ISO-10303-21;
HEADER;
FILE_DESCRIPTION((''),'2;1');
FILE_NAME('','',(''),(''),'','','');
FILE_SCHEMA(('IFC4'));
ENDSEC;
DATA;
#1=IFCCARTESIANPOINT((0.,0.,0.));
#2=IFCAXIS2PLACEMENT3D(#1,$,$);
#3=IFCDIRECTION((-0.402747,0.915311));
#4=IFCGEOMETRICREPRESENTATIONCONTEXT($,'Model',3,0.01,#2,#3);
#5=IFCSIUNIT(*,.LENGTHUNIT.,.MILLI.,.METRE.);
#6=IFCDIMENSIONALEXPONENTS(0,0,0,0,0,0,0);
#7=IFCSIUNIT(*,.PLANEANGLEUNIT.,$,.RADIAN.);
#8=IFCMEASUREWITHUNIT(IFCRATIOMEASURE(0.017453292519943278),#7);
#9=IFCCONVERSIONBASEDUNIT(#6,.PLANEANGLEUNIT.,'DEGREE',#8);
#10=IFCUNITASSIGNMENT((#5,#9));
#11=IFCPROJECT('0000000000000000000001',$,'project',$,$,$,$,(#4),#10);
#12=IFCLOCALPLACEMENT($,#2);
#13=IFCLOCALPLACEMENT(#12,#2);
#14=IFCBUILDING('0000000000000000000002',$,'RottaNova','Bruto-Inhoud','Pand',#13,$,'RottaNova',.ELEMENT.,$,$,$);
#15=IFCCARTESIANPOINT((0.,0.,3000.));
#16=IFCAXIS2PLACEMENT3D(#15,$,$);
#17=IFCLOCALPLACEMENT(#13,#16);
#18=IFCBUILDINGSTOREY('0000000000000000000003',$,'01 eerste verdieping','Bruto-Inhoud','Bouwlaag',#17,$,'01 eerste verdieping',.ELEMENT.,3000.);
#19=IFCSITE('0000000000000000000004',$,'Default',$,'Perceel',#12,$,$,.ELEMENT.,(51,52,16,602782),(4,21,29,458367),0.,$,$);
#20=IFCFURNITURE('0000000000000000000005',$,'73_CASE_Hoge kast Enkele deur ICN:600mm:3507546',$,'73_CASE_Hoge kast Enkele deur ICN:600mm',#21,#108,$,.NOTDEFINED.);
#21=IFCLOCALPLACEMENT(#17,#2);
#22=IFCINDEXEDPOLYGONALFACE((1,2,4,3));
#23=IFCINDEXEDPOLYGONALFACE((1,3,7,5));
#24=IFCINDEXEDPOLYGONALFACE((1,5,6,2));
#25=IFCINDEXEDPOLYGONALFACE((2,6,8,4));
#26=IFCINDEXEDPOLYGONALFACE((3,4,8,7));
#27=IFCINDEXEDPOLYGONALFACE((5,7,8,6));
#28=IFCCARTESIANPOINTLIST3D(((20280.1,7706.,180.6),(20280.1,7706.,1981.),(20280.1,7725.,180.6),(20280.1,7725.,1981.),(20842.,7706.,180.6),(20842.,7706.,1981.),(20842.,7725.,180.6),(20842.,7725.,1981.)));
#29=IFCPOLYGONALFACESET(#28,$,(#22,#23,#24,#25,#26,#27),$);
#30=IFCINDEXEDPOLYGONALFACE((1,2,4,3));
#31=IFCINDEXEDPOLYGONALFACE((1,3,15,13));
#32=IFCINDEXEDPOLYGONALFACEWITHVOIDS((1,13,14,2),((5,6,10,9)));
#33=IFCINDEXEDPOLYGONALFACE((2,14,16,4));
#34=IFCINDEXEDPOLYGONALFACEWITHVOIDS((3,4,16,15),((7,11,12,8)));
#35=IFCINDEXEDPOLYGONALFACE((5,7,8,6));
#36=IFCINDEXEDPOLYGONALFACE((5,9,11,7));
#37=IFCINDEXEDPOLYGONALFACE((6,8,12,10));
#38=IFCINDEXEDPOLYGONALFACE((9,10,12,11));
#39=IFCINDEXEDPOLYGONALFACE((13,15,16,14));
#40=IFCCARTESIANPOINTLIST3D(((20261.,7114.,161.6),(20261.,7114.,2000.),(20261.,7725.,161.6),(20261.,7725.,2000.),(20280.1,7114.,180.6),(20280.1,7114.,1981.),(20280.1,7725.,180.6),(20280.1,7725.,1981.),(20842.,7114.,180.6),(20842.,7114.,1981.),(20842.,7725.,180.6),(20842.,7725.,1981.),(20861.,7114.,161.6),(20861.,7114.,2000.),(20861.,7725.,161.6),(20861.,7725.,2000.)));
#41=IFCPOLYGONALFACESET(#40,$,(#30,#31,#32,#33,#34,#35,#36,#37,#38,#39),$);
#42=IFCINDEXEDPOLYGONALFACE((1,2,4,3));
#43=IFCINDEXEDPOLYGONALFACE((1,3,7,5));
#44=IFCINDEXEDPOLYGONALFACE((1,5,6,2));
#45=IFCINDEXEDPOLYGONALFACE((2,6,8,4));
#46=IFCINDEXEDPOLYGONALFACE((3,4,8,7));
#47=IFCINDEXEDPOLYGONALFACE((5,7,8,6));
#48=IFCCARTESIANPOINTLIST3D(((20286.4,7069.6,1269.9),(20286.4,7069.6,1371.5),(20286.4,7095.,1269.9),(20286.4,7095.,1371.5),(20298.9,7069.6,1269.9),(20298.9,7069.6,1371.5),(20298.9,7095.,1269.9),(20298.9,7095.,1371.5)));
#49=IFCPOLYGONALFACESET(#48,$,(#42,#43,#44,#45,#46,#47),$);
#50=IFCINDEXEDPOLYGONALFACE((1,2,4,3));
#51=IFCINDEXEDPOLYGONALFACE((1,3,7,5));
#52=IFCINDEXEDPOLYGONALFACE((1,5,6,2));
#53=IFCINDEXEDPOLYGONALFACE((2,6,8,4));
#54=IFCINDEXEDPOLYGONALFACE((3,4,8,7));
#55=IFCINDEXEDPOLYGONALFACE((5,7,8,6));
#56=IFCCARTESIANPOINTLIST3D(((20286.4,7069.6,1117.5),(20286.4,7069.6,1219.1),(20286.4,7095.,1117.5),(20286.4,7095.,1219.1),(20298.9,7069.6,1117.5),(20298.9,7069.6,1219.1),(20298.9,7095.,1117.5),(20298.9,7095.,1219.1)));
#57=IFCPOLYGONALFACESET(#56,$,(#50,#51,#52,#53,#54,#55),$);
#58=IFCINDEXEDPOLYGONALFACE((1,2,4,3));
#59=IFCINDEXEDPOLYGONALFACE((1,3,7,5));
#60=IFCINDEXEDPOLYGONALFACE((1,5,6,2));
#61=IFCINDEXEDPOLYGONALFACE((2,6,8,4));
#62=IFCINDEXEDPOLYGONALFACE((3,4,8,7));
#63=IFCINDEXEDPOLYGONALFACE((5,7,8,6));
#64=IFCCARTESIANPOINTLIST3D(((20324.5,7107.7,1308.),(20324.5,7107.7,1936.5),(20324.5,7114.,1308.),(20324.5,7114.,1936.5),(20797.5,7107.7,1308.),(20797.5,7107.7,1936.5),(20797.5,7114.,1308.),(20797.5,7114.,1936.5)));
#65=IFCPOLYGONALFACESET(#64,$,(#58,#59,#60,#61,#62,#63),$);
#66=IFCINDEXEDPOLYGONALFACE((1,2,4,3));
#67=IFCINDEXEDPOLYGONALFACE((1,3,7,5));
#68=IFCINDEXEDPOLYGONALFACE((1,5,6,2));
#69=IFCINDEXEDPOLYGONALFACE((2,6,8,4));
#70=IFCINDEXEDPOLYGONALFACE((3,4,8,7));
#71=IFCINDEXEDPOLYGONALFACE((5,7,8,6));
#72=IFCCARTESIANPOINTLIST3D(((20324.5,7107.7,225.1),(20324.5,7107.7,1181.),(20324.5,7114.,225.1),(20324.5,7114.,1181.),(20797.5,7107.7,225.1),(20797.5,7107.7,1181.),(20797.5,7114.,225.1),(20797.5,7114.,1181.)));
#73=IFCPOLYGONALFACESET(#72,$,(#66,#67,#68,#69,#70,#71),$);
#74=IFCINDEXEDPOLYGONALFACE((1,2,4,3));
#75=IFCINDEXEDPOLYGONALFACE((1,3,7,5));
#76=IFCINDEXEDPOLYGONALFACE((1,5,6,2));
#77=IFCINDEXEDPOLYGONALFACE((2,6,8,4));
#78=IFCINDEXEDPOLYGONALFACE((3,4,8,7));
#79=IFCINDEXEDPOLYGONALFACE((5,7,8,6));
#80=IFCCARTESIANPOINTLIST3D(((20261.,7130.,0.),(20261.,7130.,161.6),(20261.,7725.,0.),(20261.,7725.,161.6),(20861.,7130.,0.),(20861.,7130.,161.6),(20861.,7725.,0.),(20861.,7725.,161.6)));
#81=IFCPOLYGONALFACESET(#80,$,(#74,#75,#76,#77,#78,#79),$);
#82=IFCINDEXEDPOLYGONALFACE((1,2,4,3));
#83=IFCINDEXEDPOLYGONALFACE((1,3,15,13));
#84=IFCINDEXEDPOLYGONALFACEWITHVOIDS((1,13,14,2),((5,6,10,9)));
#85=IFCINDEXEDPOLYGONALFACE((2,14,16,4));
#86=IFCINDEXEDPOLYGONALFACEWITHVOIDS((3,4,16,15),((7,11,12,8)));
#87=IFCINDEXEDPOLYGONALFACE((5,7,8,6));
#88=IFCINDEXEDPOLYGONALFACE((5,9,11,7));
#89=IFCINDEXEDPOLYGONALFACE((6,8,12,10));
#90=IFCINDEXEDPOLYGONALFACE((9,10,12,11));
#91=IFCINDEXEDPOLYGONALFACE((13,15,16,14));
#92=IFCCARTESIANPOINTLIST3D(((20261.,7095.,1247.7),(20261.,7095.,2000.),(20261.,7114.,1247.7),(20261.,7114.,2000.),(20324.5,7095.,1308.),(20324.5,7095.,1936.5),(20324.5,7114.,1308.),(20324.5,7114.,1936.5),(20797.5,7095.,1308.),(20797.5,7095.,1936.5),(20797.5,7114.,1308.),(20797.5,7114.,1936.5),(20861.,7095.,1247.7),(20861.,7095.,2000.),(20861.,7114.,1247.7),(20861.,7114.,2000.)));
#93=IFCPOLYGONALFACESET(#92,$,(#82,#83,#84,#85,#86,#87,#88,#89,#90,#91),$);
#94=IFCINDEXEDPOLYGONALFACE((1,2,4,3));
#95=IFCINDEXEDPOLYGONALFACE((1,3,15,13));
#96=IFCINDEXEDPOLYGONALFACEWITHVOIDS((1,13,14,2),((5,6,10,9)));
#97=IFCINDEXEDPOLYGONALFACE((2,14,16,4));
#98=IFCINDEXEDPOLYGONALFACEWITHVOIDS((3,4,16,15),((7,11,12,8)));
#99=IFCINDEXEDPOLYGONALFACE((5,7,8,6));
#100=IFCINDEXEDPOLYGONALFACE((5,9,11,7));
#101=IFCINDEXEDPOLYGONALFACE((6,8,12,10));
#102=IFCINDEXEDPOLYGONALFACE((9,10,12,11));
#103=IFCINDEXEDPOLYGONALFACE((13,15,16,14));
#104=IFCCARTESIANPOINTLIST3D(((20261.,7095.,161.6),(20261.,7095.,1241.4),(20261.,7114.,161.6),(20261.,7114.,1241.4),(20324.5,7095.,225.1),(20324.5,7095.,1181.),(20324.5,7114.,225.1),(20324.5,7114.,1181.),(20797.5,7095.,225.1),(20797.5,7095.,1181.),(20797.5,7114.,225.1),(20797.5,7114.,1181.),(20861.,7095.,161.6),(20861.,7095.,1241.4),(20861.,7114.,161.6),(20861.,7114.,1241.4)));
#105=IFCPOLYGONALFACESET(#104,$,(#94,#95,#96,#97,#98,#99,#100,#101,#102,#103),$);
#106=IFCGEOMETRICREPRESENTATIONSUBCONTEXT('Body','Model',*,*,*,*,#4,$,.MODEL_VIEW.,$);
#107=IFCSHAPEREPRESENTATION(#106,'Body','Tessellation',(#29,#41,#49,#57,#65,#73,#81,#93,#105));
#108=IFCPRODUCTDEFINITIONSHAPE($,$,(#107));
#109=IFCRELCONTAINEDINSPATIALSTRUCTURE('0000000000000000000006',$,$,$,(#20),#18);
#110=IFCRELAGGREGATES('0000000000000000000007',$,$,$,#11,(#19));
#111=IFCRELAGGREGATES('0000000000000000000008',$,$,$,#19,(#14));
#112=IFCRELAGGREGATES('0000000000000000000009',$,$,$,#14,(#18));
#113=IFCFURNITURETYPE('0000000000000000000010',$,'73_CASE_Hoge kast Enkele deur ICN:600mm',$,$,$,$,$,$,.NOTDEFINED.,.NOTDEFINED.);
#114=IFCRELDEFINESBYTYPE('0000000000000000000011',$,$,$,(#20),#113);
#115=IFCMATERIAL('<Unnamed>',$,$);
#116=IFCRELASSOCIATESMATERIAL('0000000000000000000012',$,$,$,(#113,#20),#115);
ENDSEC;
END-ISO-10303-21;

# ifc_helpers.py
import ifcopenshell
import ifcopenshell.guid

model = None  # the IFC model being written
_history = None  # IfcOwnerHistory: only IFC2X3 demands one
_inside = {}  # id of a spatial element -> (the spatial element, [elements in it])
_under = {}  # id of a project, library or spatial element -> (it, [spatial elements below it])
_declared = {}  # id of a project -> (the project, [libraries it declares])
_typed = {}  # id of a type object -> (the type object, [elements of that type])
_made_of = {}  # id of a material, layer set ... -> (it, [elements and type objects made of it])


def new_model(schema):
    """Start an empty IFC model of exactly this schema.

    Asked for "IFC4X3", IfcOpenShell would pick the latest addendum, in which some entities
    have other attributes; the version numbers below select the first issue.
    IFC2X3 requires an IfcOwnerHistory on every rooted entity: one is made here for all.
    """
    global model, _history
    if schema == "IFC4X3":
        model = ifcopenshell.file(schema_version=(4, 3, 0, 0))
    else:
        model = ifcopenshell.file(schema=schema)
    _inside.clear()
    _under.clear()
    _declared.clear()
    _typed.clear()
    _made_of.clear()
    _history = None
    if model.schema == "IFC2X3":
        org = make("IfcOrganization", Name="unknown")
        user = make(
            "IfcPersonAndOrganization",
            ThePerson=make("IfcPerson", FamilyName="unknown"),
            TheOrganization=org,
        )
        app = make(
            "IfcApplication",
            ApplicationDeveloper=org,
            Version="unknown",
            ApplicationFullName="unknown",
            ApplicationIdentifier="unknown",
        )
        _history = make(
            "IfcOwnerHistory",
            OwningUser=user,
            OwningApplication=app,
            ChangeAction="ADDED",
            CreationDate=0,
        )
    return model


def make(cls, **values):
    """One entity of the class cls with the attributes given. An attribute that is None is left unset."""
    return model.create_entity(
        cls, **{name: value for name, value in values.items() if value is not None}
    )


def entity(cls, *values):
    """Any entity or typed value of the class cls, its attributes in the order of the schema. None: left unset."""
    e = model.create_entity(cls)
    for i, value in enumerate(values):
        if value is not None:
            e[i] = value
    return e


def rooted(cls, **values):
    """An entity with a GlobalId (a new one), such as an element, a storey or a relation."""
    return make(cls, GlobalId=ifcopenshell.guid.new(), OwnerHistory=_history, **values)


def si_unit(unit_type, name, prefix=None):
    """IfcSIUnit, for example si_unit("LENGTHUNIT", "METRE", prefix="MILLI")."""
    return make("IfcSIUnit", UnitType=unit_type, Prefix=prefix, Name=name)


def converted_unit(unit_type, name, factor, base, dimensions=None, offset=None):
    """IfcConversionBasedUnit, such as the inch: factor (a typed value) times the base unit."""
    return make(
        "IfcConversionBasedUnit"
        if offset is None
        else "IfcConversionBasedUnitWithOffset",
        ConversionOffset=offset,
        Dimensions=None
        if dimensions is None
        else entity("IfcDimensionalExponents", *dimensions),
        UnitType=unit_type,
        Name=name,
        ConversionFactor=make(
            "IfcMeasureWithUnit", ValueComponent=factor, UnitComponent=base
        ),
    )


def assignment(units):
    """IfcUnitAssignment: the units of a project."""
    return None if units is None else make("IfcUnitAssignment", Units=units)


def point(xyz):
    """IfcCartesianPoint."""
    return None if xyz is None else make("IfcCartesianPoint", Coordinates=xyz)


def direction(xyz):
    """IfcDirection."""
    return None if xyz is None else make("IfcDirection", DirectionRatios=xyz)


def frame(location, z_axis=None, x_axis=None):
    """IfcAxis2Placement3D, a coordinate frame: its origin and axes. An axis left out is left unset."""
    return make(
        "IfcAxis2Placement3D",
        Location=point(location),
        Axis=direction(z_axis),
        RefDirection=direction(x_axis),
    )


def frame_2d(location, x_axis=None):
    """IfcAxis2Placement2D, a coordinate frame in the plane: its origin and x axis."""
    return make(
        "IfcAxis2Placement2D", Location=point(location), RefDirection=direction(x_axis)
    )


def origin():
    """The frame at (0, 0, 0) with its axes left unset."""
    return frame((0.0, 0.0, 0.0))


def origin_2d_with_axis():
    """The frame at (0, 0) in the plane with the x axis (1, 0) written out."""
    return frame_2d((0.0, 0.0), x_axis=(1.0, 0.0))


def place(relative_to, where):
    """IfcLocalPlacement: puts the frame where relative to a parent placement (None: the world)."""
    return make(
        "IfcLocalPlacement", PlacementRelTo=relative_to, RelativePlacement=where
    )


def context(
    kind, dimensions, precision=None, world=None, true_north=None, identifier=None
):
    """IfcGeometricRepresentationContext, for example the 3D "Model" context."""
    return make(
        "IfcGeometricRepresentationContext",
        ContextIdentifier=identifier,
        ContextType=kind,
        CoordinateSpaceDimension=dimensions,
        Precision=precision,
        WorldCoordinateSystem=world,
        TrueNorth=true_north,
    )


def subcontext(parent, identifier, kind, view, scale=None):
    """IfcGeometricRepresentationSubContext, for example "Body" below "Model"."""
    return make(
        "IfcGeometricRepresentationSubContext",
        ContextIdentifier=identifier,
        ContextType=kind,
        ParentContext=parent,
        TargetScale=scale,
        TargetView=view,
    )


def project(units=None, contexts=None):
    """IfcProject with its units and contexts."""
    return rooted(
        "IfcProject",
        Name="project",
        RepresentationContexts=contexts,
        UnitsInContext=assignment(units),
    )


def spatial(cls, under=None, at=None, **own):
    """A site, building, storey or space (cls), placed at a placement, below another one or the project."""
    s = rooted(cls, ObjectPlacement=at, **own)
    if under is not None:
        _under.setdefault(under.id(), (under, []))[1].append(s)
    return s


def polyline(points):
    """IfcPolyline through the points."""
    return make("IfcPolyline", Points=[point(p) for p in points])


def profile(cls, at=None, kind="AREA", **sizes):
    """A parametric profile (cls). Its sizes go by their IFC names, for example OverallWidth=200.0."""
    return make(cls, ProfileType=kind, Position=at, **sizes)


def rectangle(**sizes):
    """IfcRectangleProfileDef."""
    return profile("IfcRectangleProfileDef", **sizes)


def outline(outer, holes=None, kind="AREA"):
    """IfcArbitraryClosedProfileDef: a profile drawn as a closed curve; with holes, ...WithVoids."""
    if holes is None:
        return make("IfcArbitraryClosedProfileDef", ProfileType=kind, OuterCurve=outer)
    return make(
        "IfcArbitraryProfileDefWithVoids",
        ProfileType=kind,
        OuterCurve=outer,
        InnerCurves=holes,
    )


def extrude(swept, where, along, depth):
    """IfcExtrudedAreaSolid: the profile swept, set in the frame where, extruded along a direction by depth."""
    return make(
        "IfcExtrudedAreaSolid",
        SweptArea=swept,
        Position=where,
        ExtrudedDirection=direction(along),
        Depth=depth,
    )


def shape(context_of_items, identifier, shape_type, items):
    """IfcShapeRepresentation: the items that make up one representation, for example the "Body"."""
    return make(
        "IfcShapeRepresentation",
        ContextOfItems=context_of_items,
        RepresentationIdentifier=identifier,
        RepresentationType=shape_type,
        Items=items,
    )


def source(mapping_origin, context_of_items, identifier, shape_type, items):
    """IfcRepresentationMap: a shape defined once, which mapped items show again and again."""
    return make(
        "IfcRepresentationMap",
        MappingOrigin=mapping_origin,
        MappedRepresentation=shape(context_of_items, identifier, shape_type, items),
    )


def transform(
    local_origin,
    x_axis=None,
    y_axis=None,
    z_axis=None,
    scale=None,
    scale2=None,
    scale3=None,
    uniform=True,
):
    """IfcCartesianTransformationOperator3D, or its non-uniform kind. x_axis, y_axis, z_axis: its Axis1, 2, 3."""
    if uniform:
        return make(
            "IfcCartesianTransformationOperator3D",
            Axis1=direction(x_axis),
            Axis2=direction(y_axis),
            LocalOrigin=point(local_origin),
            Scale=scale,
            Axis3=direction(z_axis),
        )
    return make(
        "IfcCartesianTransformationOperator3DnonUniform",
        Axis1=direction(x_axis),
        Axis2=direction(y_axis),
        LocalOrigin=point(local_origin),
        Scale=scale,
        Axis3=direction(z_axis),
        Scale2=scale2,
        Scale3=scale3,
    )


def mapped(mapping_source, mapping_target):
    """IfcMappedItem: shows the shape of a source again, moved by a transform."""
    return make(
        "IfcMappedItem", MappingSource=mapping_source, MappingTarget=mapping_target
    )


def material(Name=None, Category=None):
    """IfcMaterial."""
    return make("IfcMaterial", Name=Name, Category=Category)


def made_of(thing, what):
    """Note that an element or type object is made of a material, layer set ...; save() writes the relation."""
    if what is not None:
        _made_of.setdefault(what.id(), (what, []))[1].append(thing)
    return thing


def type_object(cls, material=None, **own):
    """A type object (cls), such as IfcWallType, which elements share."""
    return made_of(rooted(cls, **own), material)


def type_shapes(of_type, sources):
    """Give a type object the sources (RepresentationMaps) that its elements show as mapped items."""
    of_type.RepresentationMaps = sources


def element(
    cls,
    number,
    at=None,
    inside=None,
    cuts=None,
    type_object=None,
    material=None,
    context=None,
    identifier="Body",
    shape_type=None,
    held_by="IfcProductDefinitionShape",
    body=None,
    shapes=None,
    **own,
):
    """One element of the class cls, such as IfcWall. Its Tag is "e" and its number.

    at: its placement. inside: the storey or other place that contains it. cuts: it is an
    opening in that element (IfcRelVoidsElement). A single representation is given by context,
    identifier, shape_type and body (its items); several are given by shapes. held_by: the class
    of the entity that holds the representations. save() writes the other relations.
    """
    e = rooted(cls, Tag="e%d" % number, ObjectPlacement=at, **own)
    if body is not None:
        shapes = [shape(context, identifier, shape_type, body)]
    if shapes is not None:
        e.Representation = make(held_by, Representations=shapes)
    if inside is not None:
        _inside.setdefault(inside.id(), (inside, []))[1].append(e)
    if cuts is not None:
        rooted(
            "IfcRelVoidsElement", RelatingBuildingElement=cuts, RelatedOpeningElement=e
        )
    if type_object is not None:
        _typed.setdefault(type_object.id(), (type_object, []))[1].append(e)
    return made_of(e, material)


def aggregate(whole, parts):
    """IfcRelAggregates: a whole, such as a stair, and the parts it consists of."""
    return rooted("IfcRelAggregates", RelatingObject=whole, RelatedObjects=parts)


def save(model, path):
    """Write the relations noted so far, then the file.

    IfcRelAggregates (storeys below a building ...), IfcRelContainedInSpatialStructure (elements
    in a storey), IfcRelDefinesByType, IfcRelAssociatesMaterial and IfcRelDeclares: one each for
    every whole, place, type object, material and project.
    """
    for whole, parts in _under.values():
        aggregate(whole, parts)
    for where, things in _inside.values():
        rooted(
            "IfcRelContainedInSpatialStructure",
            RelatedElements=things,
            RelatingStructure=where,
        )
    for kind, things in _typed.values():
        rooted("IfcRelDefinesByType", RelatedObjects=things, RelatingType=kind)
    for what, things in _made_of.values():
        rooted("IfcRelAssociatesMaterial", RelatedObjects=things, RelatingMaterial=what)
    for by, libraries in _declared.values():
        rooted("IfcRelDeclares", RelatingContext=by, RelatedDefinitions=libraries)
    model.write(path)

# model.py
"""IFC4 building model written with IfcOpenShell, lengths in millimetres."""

from ifc_helpers import new_model, entity, si_unit, converted_unit, direction, frame, frame_2d, origin, origin_2d_with_axis, place, context, subcontext, project, spatial, polyline, rectangle, outline, extrude, source, transform, mapped, material, type_object, type_shapes, element, save


model = new_model("IFC4")

# Units and contexts
model_context = context("Model", 3, precision=0.01, world=origin(), true_north=direction((-0.402747, 0.915311)))
body_context = subcontext(model_context, "Body", "Model", "MODEL_VIEW")
ifc_project = project(units=[si_unit("LENGTHUNIT", "METRE", prefix="MILLI"), converted_unit("PLANEANGLEUNIT", "DEGREE", entity("IfcRatioMeasure", 0.017453292519943278), si_unit("PLANEANGLEUNIT", "RADIAN"), dimensions=[0, 0, 0, 0, 0, 0, 0])], contexts=[model_context])

# Site, building, storey
site_placement = place(None, origin())
site = spatial("IfcSite", under=ifc_project, at=site_placement, Name="Default", ObjectType="Perceel", CompositionType="ELEMENT", RefLatitude=(51, 52, 16, 602782), RefLongitude=(4, 21, 29, 458367), RefElevation=0.0)
building_placement = place(site_placement, origin())
building = spatial("IfcBuilding", under=site, at=building_placement, Name="RottaNova", Description="Bruto-Inhoud", ObjectType="Pand", LongName="RottaNova", CompositionType="ELEMENT")
storey_placement = place(building_placement, frame((0.0, 0.0, 3000.0)))
storey = spatial("IfcBuildingStorey", under=building, at=storey_placement, Name="01 eerste verdieping", Description="Bruto-Inhoud", ObjectType="Bouwlaag", LongName="01 eerste verdieping", CompositionType="ELEMENT", Elevation=3000.0)

# Furniture
ifc_material_1 = material(Name="<Unnamed>")
furniture_type = type_object("IfcFurnitureType", Name="73_CASE_Hoge kast Enkele deur ICN:600mm", AssemblyPlace="NOTDEFINED", PredefinedType="NOTDEFINED", material=ifc_material_1)
shared_shape_1 = source(origin(), body_context, "Body", "SweptSolid", [
    extrude(rectangle(XDim=561.9, YDim=19.1, at=origin_2d_with_axis()), frame((18.7, 9.5, 180.6), z_axis=(0.0, 0.0, 1.0), x_axis=(-1.0, 0.0, 0.0)), (0.0, 0.0, 1.0), 1800.3),
    extrude(outline(polyline([(-300.0, -919.2), (300.0, -919.2), (300.0, 919.2), (-300.0, 919.2), (-300.0, -919.2)]), holes=[polyline([(-280.9, 900.2), (281.0, 900.2), (281.0, -900.2), (-280.9, -900.2), (-280.9, 900.2)])]), frame((18.7, 0.0, 1080.8), z_axis=(0.0, 1.0, 0.0), x_axis=(-1.0, 0.0, 0.0)), (0.0, 0.0, 1.0), 610.9),
    extrude(rectangle(XDim=12.5, YDim=25.4, at=frame_2d((0.0, 0.0), x_axis=(1.0, 0.0))), frame((287.1, 642.7, 1269.9), z_axis=(0.0, 0.0, 1.0), x_axis=(-1.0, 0.0, 0.0)), (0.0, 0.0, 1.0), 101.6),
    extrude(rectangle(XDim=12.5, YDim=25.4, at=frame_2d((0.0, 0.0), x_axis=(1.0, 0.0))), frame((287.1, 642.7, 1117.5), z_axis=(0.0, 0.0, 1.0), x_axis=(-1.0, 0.0, 0.0)), (0.0, 0.0, 1.0), 101.6),
    extrude(rectangle(XDim=473.0, YDim=6.4, at=origin_2d_with_axis()), frame((18.7, 614.1, 1308.0), z_axis=(0.0, 0.0, 1.0), x_axis=(-1.0, 0.0, 0.0)), (0.0, 0.0, 1.0), 628.5),
    extrude(rectangle(XDim=473.0, YDim=6.4, at=origin_2d_with_axis()), frame((18.7, 614.1, 225.1), z_axis=(0.0, 0.0, 1.0), x_axis=(-1.0, 0.0, 0.0)), (0.0, 0.0, 1.0), 956.0),
    extrude(rectangle(XDim=595.0, YDim=600.0, at=frame_2d((0.0, 0.0), x_axis=(1.0, 0.0))), frame((18.7, 297.5, 0.0), z_axis=(0.0, 0.0, 1.0), x_axis=(0.0, 1.0, 0.0)), (0.0, 0.0, 1.0), 161.6),
    extrude(outline(polyline([(-376.1, -300.0), (376.1, -300.0), (376.1, 300.0), (-376.1, 300.0), (-376.1, -300.0)]), holes=[polyline([(-312.6, -236.5), (-312.6, 236.5), (315.8, 236.5), (315.8, -236.5), (-312.6, -236.5)])]), frame((18.7, 610.9, 1623.9), z_axis=(0.0, 1.0, 0.0), x_axis=(0.0, 0.0, -1.0)), (0.0, 0.0, 1.0), 19.1),
    extrude(outline(polyline([(-300.0, -539.9), (300.0, -539.9), (300.0, 539.9), (-300.0, 539.9), (-300.0, -539.9)]), holes=[polyline([(-236.5, 479.6), (236.5, 479.6), (236.5, -476.4), (-236.5, -476.4), (-236.5, 479.6)])]), frame((18.7, 610.9, 701.5), z_axis=(0.0, 1.0, 0.0), x_axis=(-1.0, 0.0, 0.0)), (0.0, 0.0, 1.0), 19.1),
])
type_shapes(furniture_type, [shared_shape_1])
for number, where, z_axis, x_axis, name in (
    (1, (20579.7, 7725.0, 0.0), (0.0, 0.0, 1.0), (-1.0, 0.0, 0.0), "73_CASE_Hoge kast Enkele deur ICN:600mm:3507546"),
):
    element("IfcFurniture", number, at=place(storey_placement, frame(where, z_axis=z_axis, x_axis=x_axis)), inside=storey, type_object=furniture_type, material=ifc_material_1, Name=name, ObjectType="73_CASE_Hoge kast Enkele deur ICN:600mm", PredefinedType="NOTDEFINED", context=body_context, shape_type="MappedRepresentation", body=[
        mapped(shared_shape_1, transform((0.0, 0.0, 0.0), scale=1.0)),
    ])

save(model, "model.ifc")
